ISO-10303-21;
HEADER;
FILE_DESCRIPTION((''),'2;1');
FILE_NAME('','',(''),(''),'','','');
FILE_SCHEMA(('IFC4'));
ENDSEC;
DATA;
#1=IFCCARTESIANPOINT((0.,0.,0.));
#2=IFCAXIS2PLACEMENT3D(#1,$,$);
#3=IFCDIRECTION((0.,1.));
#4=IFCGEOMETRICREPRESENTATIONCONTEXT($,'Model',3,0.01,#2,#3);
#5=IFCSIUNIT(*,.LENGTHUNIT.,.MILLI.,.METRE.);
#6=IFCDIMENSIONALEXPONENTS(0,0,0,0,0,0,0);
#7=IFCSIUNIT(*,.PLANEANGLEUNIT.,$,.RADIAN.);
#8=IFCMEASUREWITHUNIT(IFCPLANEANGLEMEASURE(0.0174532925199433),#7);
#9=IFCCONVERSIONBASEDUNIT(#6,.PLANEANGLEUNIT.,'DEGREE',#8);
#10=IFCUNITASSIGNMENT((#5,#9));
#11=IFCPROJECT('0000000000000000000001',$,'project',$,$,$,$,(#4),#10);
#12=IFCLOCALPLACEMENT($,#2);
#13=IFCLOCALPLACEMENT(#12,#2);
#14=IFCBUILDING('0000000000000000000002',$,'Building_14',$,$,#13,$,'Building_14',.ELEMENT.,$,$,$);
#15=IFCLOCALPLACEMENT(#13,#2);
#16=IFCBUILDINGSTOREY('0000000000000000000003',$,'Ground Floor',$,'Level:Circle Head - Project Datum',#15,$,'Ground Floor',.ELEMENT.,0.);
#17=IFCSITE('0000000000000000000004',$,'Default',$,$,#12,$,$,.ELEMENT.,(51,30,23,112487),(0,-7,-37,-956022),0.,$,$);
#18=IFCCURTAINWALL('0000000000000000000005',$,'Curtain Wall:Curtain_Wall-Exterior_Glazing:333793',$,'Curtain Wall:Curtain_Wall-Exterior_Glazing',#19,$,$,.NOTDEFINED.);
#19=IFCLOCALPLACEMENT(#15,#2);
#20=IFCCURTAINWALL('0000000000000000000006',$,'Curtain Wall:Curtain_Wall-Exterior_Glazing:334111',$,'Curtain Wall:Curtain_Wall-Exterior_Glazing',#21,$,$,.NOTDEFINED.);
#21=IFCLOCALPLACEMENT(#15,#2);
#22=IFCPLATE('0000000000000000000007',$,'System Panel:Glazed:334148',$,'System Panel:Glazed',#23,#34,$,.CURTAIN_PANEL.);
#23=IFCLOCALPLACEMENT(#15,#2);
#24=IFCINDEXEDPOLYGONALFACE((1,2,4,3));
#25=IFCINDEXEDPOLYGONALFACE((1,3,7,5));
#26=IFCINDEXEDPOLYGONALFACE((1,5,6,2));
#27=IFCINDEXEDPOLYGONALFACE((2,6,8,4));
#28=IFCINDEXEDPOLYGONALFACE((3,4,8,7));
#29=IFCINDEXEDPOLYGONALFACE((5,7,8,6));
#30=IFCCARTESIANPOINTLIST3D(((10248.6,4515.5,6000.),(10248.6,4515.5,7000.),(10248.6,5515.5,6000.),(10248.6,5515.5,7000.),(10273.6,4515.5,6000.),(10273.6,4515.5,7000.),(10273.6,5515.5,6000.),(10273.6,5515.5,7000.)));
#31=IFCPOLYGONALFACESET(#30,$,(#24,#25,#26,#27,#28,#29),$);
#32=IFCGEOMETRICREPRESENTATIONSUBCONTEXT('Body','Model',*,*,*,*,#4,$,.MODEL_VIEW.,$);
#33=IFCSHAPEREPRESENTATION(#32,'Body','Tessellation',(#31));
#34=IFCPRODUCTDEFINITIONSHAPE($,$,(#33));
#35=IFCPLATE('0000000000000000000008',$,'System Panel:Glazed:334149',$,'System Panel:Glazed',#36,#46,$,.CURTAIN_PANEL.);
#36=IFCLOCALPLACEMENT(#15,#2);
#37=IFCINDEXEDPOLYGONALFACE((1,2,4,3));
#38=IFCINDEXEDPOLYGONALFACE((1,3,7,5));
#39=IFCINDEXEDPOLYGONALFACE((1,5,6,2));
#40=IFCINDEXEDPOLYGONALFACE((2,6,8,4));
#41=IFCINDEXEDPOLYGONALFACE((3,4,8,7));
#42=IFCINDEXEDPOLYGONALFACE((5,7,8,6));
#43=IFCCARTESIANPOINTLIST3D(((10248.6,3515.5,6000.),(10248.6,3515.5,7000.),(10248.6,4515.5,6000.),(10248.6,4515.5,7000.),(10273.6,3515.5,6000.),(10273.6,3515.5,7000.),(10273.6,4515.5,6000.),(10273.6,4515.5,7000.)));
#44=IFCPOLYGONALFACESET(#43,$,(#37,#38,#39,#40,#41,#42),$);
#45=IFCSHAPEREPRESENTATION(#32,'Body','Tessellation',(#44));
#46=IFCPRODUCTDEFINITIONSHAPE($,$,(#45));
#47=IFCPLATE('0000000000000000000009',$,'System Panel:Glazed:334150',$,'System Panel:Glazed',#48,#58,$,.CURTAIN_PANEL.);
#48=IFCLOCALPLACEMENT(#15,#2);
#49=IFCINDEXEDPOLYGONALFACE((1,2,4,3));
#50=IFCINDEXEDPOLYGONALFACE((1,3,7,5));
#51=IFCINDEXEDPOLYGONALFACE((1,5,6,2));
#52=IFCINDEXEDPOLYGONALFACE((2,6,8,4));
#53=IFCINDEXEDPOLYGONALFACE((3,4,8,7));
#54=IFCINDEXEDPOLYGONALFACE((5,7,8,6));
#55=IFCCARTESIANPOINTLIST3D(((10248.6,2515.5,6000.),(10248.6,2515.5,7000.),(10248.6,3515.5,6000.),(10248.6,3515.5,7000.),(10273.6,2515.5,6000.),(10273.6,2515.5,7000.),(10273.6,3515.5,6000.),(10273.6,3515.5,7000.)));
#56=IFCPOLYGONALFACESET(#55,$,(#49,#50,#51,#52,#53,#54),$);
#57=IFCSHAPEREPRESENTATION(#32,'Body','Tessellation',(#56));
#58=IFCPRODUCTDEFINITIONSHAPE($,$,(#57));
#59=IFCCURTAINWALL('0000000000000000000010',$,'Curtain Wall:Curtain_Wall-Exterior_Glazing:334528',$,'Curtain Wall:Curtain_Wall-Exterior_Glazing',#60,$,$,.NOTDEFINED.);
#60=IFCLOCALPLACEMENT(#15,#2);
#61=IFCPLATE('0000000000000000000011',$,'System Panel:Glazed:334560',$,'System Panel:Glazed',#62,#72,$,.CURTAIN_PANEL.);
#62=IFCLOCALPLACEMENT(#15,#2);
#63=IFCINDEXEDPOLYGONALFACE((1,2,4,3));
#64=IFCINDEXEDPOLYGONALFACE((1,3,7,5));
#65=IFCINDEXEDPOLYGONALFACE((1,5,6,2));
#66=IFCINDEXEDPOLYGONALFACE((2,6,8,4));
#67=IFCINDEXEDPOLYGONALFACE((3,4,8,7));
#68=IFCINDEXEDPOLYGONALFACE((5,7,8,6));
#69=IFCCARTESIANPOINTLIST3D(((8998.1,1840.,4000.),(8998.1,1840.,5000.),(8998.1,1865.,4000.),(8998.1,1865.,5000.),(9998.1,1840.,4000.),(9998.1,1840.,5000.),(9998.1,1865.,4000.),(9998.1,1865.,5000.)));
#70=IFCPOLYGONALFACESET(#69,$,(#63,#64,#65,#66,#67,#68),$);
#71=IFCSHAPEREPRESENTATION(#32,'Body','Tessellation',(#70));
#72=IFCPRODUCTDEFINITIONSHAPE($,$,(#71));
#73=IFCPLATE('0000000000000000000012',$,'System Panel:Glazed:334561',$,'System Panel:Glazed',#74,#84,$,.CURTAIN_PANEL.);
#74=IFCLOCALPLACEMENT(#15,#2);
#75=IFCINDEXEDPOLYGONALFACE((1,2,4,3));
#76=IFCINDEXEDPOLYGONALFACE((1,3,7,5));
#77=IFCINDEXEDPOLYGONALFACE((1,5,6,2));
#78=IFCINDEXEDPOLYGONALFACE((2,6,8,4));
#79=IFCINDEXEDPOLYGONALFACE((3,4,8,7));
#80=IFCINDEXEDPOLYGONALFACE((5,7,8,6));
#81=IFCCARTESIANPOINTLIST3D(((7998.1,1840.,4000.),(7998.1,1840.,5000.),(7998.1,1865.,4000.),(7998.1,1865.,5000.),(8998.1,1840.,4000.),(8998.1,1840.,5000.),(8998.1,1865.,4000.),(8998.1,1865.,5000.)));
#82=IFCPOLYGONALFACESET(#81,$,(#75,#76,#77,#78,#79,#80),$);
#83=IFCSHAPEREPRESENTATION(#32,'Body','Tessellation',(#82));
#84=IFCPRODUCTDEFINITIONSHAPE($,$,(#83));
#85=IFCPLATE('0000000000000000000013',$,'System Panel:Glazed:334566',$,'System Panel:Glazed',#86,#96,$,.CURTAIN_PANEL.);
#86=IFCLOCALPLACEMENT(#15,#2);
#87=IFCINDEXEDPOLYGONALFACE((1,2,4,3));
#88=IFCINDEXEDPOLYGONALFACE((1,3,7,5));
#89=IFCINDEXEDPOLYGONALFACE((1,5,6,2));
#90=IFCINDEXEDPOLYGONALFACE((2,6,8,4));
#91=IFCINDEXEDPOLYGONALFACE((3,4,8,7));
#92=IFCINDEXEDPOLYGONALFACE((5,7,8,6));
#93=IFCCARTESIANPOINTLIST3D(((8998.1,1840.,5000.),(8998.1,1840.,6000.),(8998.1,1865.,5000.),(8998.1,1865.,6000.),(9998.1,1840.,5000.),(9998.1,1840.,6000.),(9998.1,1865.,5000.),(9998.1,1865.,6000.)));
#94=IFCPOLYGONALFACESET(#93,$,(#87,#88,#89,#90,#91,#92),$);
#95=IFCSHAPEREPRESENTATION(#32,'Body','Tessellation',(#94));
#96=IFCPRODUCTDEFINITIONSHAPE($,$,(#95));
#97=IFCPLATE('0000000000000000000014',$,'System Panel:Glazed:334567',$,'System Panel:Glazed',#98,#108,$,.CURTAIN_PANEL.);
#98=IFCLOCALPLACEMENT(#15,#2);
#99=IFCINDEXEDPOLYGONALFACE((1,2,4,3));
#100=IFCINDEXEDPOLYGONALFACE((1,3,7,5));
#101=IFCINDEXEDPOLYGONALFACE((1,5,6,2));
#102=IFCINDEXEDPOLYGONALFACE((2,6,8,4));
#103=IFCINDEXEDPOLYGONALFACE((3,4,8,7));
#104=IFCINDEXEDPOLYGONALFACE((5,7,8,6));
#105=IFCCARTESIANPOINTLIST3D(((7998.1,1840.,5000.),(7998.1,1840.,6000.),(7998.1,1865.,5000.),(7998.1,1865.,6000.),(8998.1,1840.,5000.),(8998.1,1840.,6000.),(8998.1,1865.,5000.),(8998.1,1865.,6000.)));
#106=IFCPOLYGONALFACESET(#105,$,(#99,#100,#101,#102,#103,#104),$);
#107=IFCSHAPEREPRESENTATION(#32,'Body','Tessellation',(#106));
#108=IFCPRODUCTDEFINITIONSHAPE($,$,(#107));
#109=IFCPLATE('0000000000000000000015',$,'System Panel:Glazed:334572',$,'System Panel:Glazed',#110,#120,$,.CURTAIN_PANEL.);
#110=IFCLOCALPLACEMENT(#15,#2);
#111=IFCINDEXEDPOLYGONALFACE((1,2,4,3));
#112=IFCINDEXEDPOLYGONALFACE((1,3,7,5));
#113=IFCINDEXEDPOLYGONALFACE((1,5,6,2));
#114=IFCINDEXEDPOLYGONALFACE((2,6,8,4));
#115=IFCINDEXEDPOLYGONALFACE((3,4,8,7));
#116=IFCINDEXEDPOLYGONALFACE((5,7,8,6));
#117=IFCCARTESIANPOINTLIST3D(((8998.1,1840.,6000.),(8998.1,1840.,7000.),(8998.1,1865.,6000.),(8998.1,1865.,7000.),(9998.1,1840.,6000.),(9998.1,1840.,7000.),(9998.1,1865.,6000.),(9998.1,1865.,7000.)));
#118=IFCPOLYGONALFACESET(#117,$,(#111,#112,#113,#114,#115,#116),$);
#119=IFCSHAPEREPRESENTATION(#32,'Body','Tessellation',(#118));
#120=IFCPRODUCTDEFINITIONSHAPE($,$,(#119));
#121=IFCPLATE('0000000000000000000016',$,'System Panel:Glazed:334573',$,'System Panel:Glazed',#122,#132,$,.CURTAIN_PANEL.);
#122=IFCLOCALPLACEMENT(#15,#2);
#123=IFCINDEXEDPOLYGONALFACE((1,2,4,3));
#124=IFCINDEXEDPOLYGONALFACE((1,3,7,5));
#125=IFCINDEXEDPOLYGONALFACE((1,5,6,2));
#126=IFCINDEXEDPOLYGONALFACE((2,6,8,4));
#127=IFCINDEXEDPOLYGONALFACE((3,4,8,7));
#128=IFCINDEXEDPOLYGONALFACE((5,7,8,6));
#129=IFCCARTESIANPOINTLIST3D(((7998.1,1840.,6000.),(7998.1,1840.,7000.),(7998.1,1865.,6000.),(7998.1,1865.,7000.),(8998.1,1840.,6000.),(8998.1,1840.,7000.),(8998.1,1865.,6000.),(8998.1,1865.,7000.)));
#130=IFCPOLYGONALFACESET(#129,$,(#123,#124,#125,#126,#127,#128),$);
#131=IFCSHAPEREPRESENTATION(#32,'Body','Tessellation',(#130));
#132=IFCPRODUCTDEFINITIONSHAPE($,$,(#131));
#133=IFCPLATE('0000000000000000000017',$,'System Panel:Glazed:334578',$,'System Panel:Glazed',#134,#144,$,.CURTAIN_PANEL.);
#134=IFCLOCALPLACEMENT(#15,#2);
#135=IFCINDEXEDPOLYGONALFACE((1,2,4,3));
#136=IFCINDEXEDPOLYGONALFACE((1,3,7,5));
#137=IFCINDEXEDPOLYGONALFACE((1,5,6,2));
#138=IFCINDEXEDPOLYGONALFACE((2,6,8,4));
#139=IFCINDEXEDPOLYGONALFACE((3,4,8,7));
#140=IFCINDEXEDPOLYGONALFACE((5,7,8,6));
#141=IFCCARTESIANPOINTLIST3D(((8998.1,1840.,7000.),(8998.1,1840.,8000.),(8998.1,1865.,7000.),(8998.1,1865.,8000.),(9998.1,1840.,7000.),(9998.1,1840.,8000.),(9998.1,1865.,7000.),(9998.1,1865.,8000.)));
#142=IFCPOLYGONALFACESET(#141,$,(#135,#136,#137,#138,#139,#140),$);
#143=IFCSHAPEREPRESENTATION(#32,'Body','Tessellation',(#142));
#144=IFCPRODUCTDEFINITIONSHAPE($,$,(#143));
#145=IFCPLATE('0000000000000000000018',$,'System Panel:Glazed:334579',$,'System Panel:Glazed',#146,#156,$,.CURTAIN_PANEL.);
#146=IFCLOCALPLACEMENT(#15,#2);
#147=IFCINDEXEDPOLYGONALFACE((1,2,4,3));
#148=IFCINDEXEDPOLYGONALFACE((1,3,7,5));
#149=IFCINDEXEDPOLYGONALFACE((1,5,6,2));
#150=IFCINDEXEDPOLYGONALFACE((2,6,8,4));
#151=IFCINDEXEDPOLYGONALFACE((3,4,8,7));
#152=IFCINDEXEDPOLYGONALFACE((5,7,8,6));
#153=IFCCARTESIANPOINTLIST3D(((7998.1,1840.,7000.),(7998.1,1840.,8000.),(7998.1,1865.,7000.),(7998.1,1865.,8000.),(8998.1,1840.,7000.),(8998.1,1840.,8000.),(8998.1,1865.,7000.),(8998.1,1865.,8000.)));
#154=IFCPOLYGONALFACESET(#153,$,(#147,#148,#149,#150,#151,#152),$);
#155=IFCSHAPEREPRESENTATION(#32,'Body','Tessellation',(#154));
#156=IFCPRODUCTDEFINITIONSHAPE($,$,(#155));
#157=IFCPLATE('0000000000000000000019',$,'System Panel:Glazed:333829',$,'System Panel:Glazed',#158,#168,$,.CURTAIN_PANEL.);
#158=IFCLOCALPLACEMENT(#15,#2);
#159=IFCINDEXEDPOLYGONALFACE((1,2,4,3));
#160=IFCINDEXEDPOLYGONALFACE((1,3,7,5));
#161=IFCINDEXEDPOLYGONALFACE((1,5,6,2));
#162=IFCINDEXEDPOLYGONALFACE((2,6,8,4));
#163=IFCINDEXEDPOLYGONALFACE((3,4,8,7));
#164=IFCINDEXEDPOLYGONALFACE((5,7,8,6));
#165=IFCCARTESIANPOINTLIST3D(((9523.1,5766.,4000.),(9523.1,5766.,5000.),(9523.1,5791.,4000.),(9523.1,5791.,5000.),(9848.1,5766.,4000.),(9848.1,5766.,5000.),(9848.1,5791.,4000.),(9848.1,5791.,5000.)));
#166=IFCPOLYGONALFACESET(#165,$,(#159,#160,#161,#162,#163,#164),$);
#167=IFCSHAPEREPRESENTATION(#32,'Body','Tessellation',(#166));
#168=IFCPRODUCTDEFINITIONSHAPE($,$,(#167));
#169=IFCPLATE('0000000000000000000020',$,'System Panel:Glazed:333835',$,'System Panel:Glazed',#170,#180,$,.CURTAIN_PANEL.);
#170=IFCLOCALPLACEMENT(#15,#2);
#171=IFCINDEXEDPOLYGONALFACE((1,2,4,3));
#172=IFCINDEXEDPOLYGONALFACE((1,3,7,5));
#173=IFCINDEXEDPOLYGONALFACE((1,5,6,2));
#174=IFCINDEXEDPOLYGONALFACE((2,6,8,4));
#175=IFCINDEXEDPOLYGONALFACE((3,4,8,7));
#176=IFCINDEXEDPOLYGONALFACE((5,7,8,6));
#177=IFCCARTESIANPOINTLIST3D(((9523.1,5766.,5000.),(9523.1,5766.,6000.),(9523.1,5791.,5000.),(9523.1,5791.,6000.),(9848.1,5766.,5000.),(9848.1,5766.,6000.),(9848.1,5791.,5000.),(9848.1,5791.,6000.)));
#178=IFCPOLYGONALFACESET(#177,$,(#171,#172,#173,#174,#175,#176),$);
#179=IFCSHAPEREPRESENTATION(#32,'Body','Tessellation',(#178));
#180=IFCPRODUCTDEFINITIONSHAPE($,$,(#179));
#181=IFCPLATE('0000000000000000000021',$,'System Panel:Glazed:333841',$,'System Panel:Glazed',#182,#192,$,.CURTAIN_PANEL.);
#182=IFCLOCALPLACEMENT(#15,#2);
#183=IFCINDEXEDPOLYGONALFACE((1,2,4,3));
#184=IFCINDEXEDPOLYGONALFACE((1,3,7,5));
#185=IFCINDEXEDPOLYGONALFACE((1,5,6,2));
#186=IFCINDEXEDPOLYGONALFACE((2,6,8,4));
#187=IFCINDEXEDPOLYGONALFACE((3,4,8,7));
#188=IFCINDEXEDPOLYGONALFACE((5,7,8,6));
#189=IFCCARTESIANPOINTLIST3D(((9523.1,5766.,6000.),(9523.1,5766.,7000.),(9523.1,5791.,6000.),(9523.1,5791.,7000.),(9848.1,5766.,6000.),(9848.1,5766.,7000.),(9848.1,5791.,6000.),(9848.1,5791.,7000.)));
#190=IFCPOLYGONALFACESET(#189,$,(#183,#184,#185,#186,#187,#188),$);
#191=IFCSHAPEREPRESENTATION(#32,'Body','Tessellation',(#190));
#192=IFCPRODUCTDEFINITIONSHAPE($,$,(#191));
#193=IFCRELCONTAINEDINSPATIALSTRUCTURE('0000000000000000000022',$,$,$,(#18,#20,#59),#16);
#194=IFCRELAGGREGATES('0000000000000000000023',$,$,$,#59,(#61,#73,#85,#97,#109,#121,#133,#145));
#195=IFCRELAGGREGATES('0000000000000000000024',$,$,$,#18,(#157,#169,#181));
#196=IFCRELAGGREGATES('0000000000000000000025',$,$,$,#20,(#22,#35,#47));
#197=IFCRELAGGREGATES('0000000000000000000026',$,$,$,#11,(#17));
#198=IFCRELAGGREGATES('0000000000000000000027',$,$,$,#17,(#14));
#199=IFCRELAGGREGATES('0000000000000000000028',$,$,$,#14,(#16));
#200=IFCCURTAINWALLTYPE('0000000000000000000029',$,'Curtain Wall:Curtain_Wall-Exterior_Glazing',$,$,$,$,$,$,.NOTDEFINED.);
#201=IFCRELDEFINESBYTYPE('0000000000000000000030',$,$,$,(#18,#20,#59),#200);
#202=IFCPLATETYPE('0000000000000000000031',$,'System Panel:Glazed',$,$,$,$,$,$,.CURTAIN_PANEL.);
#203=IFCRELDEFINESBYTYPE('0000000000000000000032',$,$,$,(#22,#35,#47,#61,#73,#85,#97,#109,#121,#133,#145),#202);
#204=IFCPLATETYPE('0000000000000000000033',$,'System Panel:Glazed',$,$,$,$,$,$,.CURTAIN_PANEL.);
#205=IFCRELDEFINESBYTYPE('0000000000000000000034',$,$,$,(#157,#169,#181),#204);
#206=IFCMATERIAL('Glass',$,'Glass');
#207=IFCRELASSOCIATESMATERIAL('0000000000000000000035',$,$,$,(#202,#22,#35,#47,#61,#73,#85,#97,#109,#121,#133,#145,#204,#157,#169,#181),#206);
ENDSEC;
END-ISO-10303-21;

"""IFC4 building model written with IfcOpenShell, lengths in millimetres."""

from ifc_helpers import new_model, entity, si_unit, converted_unit, direction, frame, origin, place, context, subcontext, project, spatial, indexed_curve, outline, extrude, source, transform, mapped, material, type_object, type_shapes, element, aggregate, save


model = new_model("IFC4")

# Units and contexts
model_context = context("Model", 3, precision=0.01, world=origin(), true_north=direction((0.0, 1.0)))
body_context = subcontext(model_context, "Body", "Model", "MODEL_VIEW")
ifc_project = project(units=[si_unit("LENGTHUNIT", "METRE", prefix="MILLI"), converted_unit("PLANEANGLEUNIT", "DEGREE", entity("IfcPlaneAngleMeasure", 0.0174532925199433), si_unit("PLANEANGLEUNIT", "RADIAN"), dimensions=[0, 0, 0, 0, 0, 0, 0])], contexts=[model_context])

# Site, building, storey
site_placement = place(None, origin())
site = spatial("IfcSite", under=ifc_project, at=site_placement, Name="Default", CompositionType="ELEMENT", RefLatitude=(51, 30, 23, 112487), RefLongitude=(0, -7, -37, -956022), RefElevation=0.0)
building_placement = place(site_placement, origin())
building = spatial("IfcBuilding", under=site, at=building_placement, Name="Building_14", LongName="Building_14", CompositionType="ELEMENT")
storey_placement = place(building_placement, origin())
storey = spatial("IfcBuildingStorey", under=building, at=storey_placement, Name="Ground Floor", ObjectType="Level:Circle Head - Project Datum", LongName="Ground Floor", CompositionType="ELEMENT", Elevation=0.0)

# Curtain walls, plates
curtain_wall_type = type_object("IfcCurtainWallType", Name="Curtain Wall:Curtain_Wall-Exterior_Glazing", PredefinedType="NOTDEFINED")
curtain_wall_1_placement = place(storey_placement, origin())
curtain_wall_1 = element("IfcCurtainWall", 1, at=curtain_wall_1_placement, inside=storey, type_object=curtain_wall_type, Name="Curtain Wall:Curtain_Wall-Exterior_Glazing:333793", ObjectType="Curtain Wall:Curtain_Wall-Exterior_Glazing", PredefinedType="NOTDEFINED")
ifc_material = material(Name="Glass", Category="Glass")
plate_type_1 = type_object("IfcPlateType", Name="System Panel:Glazed", PredefinedType="CURTAIN_PANEL", material=ifc_material)
shared_shape_1 = source(origin(), body_context, "Body", "SweptSolid", [
    extrude(outline(indexed_curve([(-12.5, -500.0), (12.5, -500.0), (12.5, 500.0), (-12.5, 500.0), (-12.5, -500.0)], self_intersect=False)), frame((0.0, -37.0, 0.0), z_axis=(0.0, 0.0, 1.0), x_axis=(0.0, 1.0, 0.0)), (0.0, 0.0, 1.0), 1000.0),
])
type_shapes(plate_type_1, [shared_shape_1])
curtain_wall_2_placement = place(storey_placement, origin())
curtain_wall_2 = element("IfcCurtainWall", 2, at=curtain_wall_2_placement, inside=storey, type_object=curtain_wall_type, Name="Curtain Wall:Curtain_Wall-Exterior_Glazing:334111", ObjectType="Curtain Wall:Curtain_Wall-Exterior_Glazing", PredefinedType="NOTDEFINED")
plate_1_placement = place(curtain_wall_2_placement, frame((10298.1, 5015.5, 6000.0), z_axis=(0.0, 0.0, 1.0), x_axis=(0.0, -1.0, 0.0)))
plate_1 = element("IfcPlate", 3, at=plate_1_placement, type_object=plate_type_1, material=ifc_material, Name="System Panel:Glazed:334148", ObjectType="System Panel:Glazed", PredefinedType="CURTAIN_PANEL", context=body_context, shape_type="MappedRepresentation", body=[
    mapped(shared_shape_1, transform((0.0, 0.0, 0.0), scale=1.0)),
])
plate_2_placement = place(curtain_wall_2_placement, frame((10298.1, 4015.5, 6000.0), z_axis=(0.0, 0.0, 1.0), x_axis=(0.0, -1.0, 0.0)))
plate_2 = element("IfcPlate", 4, at=plate_2_placement, type_object=plate_type_1, material=ifc_material, Name="System Panel:Glazed:334149", ObjectType="System Panel:Glazed", PredefinedType="CURTAIN_PANEL", context=body_context, shape_type="MappedRepresentation", body=[
    mapped(shared_shape_1, transform((0.0, 0.0, 0.0), scale=1.0)),
])
plate_3_placement = place(curtain_wall_2_placement, frame((10298.1, 3015.5, 6000.0), z_axis=(0.0, 0.0, 1.0), x_axis=(0.0, -1.0, 0.0)))
plate_3 = element("IfcPlate", 5, at=plate_3_placement, type_object=plate_type_1, material=ifc_material, Name="System Panel:Glazed:334150", ObjectType="System Panel:Glazed", PredefinedType="CURTAIN_PANEL", context=body_context, shape_type="MappedRepresentation", body=[
    mapped(shared_shape_1, transform((0.0, 0.0, 0.0), scale=1.0)),
])
curtain_wall_3_placement = place(storey_placement, origin())
curtain_wall_3 = element("IfcCurtainWall", 6, at=curtain_wall_3_placement, inside=storey, type_object=curtain_wall_type, Name="Curtain Wall:Curtain_Wall-Exterior_Glazing:334528", ObjectType="Curtain Wall:Curtain_Wall-Exterior_Glazing", PredefinedType="NOTDEFINED")
plate_4_placement = place(curtain_wall_3_placement, frame((9498.1, 1815.5, 4000.0), z_axis=(0.0, 0.0, 1.0), x_axis=(-1.0, 0.0, 0.0)))
plate_4 = element("IfcPlate", 7, at=plate_4_placement, type_object=plate_type_1, material=ifc_material, Name="System Panel:Glazed:334560", ObjectType="System Panel:Glazed", PredefinedType="CURTAIN_PANEL", context=body_context, shape_type="MappedRepresentation", body=[
    mapped(shared_shape_1, transform((0.0, 0.0, 0.0), scale=1.0)),
])
plate_5_placement = place(curtain_wall_3_placement, frame((8498.1, 1815.5, 4000.0), z_axis=(0.0, 0.0, 1.0), x_axis=(-1.0, 0.0, 0.0)))
plate_5 = element("IfcPlate", 8, at=plate_5_placement, type_object=plate_type_1, material=ifc_material, Name="System Panel:Glazed:334561", ObjectType="System Panel:Glazed", PredefinedType="CURTAIN_PANEL", context=body_context, shape_type="MappedRepresentation", body=[
    mapped(shared_shape_1, transform((0.0, 0.0, 0.0), scale=1.0)),
])
plate_6_placement = place(curtain_wall_3_placement, frame((9498.1, 1815.5, 5000.0), z_axis=(0.0, 0.0, 1.0), x_axis=(-1.0, 0.0, 0.0)))
plate_6 = element("IfcPlate", 9, at=plate_6_placement, type_object=plate_type_1, material=ifc_material, Name="System Panel:Glazed:334566", ObjectType="System Panel:Glazed", PredefinedType="CURTAIN_PANEL", context=body_context, shape_type="MappedRepresentation", body=[
    mapped(shared_shape_1, transform((0.0, 0.0, 0.0), scale=1.0)),
])
plate_7_placement = place(curtain_wall_3_placement, frame((8498.1, 1815.5, 5000.0), z_axis=(0.0, 0.0, 1.0), x_axis=(-1.0, 0.0, 0.0)))
plate_7 = element("IfcPlate", 10, at=plate_7_placement, type_object=plate_type_1, material=ifc_material, Name="System Panel:Glazed:334567", ObjectType="System Panel:Glazed", PredefinedType="CURTAIN_PANEL", context=body_context, shape_type="MappedRepresentation", body=[
    mapped(shared_shape_1, transform((0.0, 0.0, 0.0), scale=1.0)),
])
plate_8_placement = place(curtain_wall_3_placement, frame((9498.1, 1815.5, 6000.0), z_axis=(0.0, 0.0, 1.0), x_axis=(-1.0, 0.0, 0.0)))
plate_8 = element("IfcPlate", 11, at=plate_8_placement, type_object=plate_type_1, material=ifc_material, Name="System Panel:Glazed:334572", ObjectType="System Panel:Glazed", PredefinedType="CURTAIN_PANEL", context=body_context, shape_type="MappedRepresentation", body=[
    mapped(shared_shape_1, transform((0.0, 0.0, 0.0), scale=1.0)),
])
plate_9_placement = place(curtain_wall_3_placement, frame((8498.1, 1815.5, 6000.0), z_axis=(0.0, 0.0, 1.0), x_axis=(-1.0, 0.0, 0.0)))
plate_9 = element("IfcPlate", 12, at=plate_9_placement, type_object=plate_type_1, material=ifc_material, Name="System Panel:Glazed:334573", ObjectType="System Panel:Glazed", PredefinedType="CURTAIN_PANEL", context=body_context, shape_type="MappedRepresentation", body=[
    mapped(shared_shape_1, transform((0.0, 0.0, 0.0), scale=1.0)),
])
plate_10_placement = place(curtain_wall_3_placement, frame((9498.1, 1815.5, 7000.0), z_axis=(0.0, 0.0, 1.0), x_axis=(-1.0, 0.0, 0.0)))
plate_10 = element("IfcPlate", 13, at=plate_10_placement, type_object=plate_type_1, material=ifc_material, Name="System Panel:Glazed:334578", ObjectType="System Panel:Glazed", PredefinedType="CURTAIN_PANEL", context=body_context, shape_type="MappedRepresentation", body=[
    mapped(shared_shape_1, transform((0.0, 0.0, 0.0), scale=1.0)),
])
plate_11_placement = place(curtain_wall_3_placement, frame((8498.1, 1815.5, 7000.0), z_axis=(0.0, 0.0, 1.0), x_axis=(-1.0, 0.0, 0.0)))
plate_11 = element("IfcPlate", 14, at=plate_11_placement, type_object=plate_type_1, material=ifc_material, Name="System Panel:Glazed:334579", ObjectType="System Panel:Glazed", PredefinedType="CURTAIN_PANEL", context=body_context, shape_type="MappedRepresentation", body=[
    mapped(shared_shape_1, transform((0.0, 0.0, 0.0), scale=1.0)),
])
aggregate(curtain_wall_3, [plate_4, plate_5, plate_6, plate_7, plate_8, plate_9, plate_10, plate_11])

# Plates
plate_type_2 = type_object("IfcPlateType", Name="System Panel:Glazed", PredefinedType="CURTAIN_PANEL", material=ifc_material)
shared_shape_2 = source(origin(), body_context, "Body", "SweptSolid", [
    extrude(outline(indexed_curve([(-12.5, -162.5), (12.5, -162.5), (12.5, 162.5), (-12.5, 162.5), (-12.5, -162.5)], self_intersect=False)), frame((0.0, -37.0, 0.0), z_axis=(0.0, 0.0, 1.0), x_axis=(0.0, 1.0, 0.0)), (0.0, 0.0, 1.0), 1000.0),
])
type_shapes(plate_type_2, [shared_shape_2])
plate_12_placement = place(curtain_wall_1_placement, frame((9685.6, 5815.5, 4000.0)))
plate_12 = element("IfcPlate", 15, at=plate_12_placement, type_object=plate_type_2, material=ifc_material, Name="System Panel:Glazed:333829", ObjectType="System Panel:Glazed", PredefinedType="CURTAIN_PANEL", context=body_context, shape_type="MappedRepresentation", body=[
    mapped(shared_shape_2, transform((0.0, 0.0, 0.0), scale=1.0)),
])
plate_13_placement = place(curtain_wall_1_placement, frame((9685.6, 5815.5, 5000.0)))
plate_13 = element("IfcPlate", 16, at=plate_13_placement, type_object=plate_type_2, material=ifc_material, Name="System Panel:Glazed:333835", ObjectType="System Panel:Glazed", PredefinedType="CURTAIN_PANEL", context=body_context, shape_type="MappedRepresentation", body=[
    mapped(shared_shape_2, transform((0.0, 0.0, 0.0), scale=1.0)),
])
plate_14_placement = place(curtain_wall_1_placement, frame((9685.6, 5815.5, 6000.0)))
plate_14 = element("IfcPlate", 17, at=plate_14_placement, type_object=plate_type_2, material=ifc_material, Name="System Panel:Glazed:333841", ObjectType="System Panel:Glazed", PredefinedType="CURTAIN_PANEL", context=body_context, shape_type="MappedRepresentation", body=[
    mapped(shared_shape_2, transform((0.0, 0.0, 0.0), scale=1.0)),
])
aggregate(curtain_wall_1, [plate_12, plate_13, plate_14])
aggregate(curtain_wall_2, [plate_1, plate_2, plate_3])

save(model, "model.ifc")
